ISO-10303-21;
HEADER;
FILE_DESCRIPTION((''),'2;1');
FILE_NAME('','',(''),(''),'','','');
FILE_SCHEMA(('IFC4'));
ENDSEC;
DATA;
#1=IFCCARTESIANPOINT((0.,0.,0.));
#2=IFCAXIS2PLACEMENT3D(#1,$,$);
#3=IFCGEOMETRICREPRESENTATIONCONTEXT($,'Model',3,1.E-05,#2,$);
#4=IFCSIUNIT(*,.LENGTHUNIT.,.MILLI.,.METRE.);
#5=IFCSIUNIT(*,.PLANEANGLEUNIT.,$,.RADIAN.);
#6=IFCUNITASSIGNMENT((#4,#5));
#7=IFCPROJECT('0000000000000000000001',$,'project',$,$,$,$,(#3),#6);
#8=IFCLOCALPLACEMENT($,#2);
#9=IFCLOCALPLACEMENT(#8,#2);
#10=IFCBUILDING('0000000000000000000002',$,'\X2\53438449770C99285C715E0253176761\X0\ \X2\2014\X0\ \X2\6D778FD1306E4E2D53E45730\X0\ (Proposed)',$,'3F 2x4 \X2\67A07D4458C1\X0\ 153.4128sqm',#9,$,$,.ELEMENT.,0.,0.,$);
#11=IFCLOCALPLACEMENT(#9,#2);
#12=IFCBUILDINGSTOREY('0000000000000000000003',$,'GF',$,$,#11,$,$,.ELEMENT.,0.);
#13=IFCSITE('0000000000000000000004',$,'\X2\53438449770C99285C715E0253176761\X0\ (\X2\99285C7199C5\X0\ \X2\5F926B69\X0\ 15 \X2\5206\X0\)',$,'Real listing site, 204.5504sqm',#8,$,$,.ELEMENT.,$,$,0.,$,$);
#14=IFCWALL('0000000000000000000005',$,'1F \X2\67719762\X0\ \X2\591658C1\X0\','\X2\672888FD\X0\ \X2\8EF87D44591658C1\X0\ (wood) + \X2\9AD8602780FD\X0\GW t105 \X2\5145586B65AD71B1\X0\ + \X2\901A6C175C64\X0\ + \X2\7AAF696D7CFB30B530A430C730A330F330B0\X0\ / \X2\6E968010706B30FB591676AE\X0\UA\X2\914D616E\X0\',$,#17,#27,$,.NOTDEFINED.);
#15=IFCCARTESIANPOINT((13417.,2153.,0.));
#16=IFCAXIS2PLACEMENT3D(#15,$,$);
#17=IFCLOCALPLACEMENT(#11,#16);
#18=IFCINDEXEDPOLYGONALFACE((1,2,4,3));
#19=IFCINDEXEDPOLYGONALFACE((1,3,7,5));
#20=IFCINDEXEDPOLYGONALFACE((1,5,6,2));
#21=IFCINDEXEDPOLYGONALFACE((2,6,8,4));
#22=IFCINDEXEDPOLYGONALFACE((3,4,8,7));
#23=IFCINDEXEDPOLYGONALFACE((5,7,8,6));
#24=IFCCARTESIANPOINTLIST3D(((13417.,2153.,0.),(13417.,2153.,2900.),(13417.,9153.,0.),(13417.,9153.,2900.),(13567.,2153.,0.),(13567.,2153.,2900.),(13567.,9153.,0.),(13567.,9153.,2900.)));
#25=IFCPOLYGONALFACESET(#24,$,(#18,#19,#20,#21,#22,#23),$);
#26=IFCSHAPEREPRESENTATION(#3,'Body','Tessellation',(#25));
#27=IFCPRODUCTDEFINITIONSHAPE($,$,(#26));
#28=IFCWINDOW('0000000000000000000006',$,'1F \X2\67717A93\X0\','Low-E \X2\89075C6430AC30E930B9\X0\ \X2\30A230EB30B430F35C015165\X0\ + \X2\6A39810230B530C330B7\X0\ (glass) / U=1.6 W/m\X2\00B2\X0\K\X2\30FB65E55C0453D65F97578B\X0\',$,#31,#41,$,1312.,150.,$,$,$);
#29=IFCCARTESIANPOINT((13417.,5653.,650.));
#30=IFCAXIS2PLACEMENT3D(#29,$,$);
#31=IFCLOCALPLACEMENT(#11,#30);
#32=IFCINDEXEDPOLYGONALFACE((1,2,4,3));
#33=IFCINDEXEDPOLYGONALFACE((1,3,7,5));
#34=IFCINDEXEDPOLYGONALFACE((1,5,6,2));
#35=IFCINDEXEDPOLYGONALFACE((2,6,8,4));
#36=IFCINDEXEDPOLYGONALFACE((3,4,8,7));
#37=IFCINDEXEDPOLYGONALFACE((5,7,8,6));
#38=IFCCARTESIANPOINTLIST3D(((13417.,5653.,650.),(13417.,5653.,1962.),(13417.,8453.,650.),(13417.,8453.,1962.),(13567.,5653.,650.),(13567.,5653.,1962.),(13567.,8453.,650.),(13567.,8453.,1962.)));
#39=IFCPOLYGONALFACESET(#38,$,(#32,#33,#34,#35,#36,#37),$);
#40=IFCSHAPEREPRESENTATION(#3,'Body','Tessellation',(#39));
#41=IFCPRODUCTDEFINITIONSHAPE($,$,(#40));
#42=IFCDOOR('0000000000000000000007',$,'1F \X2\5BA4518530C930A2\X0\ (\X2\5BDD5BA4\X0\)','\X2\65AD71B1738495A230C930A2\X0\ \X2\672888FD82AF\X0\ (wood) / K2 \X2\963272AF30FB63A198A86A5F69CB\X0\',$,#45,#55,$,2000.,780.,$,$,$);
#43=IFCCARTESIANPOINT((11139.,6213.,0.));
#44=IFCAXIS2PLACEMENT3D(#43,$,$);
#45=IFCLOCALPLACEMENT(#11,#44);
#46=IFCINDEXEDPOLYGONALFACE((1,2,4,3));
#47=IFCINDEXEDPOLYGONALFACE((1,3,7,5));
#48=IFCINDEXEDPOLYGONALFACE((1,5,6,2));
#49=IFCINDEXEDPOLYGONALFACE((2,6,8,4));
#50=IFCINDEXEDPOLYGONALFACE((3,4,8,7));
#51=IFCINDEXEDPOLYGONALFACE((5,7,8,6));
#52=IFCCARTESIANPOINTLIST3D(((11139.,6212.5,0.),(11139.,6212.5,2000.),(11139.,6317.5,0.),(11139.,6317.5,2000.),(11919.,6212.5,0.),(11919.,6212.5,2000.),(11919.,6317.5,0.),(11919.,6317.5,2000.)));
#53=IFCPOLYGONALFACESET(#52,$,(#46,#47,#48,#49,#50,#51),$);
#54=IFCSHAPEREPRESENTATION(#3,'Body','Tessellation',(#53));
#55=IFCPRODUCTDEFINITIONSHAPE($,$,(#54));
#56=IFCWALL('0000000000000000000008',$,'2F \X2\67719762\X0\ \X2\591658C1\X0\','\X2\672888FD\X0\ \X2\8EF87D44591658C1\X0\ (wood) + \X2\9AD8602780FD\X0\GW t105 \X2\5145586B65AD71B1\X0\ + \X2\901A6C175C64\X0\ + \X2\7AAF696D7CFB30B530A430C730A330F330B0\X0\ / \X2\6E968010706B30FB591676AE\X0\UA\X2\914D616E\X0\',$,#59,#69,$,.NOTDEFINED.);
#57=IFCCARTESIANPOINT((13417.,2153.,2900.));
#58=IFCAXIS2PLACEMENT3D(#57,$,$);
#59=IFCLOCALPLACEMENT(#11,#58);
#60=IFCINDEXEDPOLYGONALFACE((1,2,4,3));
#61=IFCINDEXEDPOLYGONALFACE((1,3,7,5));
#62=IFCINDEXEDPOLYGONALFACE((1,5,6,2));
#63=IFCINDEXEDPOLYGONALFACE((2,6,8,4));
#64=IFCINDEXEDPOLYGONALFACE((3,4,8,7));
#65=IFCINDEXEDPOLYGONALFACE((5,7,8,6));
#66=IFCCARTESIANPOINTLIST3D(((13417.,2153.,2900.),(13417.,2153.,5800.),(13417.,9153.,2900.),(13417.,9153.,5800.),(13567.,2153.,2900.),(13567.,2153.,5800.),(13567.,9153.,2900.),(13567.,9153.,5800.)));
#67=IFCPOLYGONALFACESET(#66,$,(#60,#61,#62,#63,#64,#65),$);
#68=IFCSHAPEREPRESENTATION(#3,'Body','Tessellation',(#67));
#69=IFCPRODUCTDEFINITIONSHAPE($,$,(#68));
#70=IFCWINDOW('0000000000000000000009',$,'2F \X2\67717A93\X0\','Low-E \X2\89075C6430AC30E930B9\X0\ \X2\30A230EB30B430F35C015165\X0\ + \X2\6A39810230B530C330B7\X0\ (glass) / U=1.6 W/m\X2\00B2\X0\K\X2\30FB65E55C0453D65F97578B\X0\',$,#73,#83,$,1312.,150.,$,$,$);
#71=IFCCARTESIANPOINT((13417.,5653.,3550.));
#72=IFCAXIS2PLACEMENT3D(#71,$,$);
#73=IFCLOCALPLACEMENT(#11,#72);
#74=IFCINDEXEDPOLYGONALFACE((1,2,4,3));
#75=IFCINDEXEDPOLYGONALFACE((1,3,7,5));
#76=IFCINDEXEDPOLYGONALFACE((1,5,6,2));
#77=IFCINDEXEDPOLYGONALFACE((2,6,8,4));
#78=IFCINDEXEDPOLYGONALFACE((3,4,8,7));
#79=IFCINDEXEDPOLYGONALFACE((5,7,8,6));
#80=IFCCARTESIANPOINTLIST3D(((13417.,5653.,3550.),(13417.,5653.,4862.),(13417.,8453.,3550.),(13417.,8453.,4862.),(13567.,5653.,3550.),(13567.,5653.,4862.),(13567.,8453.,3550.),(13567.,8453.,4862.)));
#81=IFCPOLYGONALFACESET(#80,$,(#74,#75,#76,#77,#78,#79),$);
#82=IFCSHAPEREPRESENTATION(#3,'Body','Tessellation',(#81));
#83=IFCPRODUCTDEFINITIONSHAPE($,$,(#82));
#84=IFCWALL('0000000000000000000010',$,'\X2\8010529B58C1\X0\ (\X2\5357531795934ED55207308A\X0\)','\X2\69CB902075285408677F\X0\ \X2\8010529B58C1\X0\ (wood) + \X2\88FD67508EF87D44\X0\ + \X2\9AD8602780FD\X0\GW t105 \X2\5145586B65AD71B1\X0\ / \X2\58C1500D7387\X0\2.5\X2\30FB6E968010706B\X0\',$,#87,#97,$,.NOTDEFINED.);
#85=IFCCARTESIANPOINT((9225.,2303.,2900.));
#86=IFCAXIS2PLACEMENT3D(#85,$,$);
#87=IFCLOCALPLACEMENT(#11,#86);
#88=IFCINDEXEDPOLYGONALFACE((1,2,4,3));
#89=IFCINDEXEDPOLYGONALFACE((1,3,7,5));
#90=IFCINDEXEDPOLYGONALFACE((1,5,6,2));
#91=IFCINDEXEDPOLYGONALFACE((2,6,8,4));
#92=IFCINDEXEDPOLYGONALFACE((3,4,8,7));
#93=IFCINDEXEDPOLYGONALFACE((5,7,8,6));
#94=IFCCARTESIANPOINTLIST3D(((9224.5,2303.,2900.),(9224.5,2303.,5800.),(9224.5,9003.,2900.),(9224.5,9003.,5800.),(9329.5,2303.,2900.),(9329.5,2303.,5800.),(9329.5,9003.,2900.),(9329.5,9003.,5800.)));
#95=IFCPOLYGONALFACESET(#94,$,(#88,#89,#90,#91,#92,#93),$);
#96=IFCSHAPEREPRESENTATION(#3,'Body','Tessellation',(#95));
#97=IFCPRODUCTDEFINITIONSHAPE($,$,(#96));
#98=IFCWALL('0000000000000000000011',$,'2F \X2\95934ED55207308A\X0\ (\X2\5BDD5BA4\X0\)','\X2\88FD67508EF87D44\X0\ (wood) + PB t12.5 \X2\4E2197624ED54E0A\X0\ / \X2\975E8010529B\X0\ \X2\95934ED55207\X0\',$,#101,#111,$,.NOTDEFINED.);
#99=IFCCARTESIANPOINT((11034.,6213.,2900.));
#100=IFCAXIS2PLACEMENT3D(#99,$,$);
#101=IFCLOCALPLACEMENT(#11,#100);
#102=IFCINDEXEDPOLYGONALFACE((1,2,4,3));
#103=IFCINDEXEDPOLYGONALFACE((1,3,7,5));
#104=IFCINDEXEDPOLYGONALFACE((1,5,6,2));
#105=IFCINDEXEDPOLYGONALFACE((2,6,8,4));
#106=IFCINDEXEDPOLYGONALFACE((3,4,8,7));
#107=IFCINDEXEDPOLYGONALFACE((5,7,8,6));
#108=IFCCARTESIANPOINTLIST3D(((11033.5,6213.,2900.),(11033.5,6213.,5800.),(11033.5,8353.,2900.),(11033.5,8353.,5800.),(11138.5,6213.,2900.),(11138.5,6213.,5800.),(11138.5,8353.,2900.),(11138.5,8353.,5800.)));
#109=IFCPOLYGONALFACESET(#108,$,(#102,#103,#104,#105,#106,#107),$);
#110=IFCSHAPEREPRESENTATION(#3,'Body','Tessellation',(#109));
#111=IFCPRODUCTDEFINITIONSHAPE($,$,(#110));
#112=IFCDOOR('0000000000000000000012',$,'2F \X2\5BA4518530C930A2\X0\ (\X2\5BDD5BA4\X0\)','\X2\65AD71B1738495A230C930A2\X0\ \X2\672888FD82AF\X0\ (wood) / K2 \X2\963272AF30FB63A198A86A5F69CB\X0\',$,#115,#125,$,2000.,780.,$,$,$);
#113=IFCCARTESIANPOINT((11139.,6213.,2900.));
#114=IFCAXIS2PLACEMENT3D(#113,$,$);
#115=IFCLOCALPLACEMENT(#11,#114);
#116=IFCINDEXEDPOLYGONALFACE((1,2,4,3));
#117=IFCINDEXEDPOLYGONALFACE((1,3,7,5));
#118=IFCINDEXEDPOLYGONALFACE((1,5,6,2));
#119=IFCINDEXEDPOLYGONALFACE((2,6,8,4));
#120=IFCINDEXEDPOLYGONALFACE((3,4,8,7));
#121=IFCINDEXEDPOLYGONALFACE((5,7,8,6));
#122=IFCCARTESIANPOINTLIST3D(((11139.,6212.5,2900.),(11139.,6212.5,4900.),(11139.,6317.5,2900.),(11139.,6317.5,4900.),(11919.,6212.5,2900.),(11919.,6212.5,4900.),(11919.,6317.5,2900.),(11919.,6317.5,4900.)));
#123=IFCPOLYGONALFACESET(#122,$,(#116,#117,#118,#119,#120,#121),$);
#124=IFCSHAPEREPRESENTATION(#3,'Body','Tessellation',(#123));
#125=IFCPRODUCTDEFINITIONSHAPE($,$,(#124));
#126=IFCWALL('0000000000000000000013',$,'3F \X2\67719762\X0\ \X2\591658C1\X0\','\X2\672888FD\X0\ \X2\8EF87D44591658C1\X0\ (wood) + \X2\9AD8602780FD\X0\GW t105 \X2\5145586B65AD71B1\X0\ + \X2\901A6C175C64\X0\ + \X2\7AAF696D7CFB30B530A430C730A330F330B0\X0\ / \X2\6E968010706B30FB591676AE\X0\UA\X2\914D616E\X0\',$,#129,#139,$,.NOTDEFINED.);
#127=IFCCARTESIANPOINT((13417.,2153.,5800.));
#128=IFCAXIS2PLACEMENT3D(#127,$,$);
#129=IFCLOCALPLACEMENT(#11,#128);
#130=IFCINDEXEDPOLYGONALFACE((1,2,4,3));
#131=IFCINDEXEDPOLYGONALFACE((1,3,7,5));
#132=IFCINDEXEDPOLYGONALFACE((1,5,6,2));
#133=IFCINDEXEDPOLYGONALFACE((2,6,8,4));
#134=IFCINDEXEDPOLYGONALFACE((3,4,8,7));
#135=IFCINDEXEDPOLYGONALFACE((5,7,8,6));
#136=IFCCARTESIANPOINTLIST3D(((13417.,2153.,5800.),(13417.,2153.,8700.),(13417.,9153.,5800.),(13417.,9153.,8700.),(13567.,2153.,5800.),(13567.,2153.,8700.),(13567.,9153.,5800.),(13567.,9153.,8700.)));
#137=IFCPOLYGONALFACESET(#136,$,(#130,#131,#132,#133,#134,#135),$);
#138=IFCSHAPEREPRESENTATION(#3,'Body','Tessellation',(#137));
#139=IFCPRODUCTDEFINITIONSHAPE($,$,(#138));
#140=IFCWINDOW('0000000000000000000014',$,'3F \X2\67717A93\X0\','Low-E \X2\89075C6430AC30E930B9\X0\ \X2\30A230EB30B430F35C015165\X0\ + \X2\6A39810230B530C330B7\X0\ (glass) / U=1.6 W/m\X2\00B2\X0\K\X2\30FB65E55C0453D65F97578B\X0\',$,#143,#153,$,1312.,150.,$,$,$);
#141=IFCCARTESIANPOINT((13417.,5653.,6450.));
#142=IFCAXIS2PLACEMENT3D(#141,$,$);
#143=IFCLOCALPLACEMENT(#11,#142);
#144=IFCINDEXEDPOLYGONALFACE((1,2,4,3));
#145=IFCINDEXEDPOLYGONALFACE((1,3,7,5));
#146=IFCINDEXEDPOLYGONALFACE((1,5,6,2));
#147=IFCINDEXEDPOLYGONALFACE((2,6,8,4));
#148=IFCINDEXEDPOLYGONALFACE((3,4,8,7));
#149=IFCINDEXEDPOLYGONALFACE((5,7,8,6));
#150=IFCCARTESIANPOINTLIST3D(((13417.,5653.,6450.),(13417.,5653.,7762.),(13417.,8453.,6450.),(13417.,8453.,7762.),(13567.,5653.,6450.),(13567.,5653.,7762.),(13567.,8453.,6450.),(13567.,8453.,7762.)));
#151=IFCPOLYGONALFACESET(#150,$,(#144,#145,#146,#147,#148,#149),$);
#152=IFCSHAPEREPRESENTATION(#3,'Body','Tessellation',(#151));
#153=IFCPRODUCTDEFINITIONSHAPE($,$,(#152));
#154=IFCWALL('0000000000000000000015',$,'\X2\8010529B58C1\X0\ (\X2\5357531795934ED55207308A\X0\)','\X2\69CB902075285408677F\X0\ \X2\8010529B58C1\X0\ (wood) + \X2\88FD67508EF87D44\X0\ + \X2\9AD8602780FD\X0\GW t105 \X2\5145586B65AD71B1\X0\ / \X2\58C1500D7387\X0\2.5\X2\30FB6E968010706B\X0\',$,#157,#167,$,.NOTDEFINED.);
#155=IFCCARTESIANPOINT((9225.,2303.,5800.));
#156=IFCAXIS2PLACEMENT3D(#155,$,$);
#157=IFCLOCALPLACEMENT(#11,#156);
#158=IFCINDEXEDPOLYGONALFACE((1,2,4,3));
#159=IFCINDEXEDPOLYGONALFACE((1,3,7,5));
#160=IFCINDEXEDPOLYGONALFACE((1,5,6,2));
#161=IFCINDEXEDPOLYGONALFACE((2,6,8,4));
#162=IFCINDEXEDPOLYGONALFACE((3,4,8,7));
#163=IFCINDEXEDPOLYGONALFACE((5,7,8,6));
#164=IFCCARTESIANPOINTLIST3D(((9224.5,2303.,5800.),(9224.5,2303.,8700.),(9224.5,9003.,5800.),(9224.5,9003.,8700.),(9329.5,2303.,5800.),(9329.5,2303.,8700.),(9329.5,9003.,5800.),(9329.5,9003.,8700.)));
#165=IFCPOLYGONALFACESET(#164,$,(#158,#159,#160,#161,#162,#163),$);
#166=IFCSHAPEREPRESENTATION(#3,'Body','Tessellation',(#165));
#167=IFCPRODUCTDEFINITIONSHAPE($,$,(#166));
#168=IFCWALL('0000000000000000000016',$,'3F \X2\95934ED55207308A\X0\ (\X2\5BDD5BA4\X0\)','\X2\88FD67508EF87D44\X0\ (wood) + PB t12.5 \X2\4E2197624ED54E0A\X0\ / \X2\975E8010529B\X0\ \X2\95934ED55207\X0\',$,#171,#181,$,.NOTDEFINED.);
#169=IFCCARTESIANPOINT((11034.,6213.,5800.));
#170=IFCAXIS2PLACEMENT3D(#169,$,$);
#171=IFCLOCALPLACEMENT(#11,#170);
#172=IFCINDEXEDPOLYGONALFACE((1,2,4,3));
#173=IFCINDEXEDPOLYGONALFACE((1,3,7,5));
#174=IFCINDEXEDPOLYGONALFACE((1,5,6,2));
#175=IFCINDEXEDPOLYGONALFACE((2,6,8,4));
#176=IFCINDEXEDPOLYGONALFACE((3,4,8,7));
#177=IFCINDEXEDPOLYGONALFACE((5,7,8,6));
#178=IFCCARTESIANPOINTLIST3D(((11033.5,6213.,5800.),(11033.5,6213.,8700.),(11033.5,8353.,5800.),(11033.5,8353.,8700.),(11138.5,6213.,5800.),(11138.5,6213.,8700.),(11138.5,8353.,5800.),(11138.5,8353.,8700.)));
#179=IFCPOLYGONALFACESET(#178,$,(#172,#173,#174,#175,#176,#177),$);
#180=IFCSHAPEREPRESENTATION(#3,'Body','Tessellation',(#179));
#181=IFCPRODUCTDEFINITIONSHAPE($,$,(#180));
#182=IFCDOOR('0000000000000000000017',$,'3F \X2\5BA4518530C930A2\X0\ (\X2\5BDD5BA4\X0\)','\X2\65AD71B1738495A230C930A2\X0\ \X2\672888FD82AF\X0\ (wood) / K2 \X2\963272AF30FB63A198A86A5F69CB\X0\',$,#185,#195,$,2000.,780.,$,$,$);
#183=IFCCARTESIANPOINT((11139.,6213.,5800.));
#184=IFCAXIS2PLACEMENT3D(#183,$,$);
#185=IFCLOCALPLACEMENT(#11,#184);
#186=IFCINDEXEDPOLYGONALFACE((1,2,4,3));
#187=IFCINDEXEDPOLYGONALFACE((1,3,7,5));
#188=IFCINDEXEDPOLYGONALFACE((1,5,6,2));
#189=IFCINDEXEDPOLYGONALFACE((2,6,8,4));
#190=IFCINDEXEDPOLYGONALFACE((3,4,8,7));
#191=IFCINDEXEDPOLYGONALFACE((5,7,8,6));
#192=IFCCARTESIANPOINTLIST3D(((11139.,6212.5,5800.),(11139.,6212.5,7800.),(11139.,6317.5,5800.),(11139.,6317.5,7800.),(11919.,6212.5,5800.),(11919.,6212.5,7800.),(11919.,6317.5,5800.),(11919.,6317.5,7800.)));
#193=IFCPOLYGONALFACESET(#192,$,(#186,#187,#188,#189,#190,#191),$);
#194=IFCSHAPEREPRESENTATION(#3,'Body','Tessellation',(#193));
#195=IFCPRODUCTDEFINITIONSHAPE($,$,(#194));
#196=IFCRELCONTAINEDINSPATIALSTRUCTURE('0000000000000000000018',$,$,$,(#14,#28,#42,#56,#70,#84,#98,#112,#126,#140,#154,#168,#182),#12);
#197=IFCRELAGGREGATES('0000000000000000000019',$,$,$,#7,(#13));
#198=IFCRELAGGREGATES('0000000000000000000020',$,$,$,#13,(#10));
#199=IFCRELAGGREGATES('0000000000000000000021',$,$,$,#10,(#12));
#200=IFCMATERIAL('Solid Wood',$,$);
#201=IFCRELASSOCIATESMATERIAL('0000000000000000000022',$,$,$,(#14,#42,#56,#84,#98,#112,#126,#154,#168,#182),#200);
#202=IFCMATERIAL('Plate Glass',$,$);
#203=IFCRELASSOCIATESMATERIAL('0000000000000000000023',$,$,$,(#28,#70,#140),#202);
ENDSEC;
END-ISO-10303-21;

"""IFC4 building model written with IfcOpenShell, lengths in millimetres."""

from ifc_helpers import new_model, si_unit, frame, frame_2d, origin, place, context, project, spatial, rectangle, extrude, material, element, fill, save


model = new_model("IFC4")

# Units and contexts
model_context = context("Model", 3, precision=1e-05, world=origin())
ifc_project = project(units=[si_unit("LENGTHUNIT", "METRE", prefix="MILLI"), si_unit("PLANEANGLEUNIT", "RADIAN")], contexts=[model_context])

# Site, building, storey
site_placement = place(None, origin())
site = spatial("IfcSite", under=ifc_project, at=site_placement, Name="千葉県館山市北条 (館山駅 徒歩 15 分)", ObjectType="Real listing site, 204.5504sqm", CompositionType="ELEMENT", RefElevation=0.0)
building_placement = place(site_placement, origin())
building = spatial("IfcBuilding", under=site, at=building_placement, Name="千葉県館山市北条 — 海近の中古地 (Proposed)", ObjectType="3F 2x4 枠組壁 153.4128sqm", CompositionType="ELEMENT", ElevationOfRefHeight=0.0, ElevationOfTerrain=0.0)
storey_placement = place(building_placement, origin())
storey = spatial("IfcBuildingStorey", under=building, at=storey_placement, Name="GF", CompositionType="ELEMENT", Elevation=0.0)

# Wall, opening, window
ifc_material_1 = material(Name="Solid Wood")
wall_1_placement = place(storey_placement, frame((13417.0, 2153.0, 0.0)))
wall_1 = element("IfcWall", 1, at=wall_1_placement, inside=storey, material=ifc_material_1, Name="1F 東面 外壁", Description="木製 軸組外壁 (wood) + 高性能GW t105 充填断熱 + 通気層 + 窯業系サイディング / 準耐火・外皮UA配慮", PredefinedType="NOTDEFINED", context=model_context, shape_type="SweptSolid", body=[
    extrude(rectangle(XDim=150.0, YDim=7000.0, at=frame_2d((75.0, 3500.0))), frame((13417.0, 2153.0, 0.0)), (0.0, 0.0, 1.0), 2900.0),
])
opening_1_placement = place(storey_placement, frame((13417.0, 5653.0, 650.0)))
opening_1 = element("IfcOpeningElement", 2, at=opening_1_placement, cuts=wall_1, PredefinedType="NOTDEFINED", context=model_context, shape_type="SweptSolid", body=[
    extrude(rectangle(XDim=150.0, YDim=2800.0, at=frame_2d((75.0, 1400.0))), frame((13417.0, 5653.0, 650.0)), (0.0, 0.0, 1.0), 1312.0),
])
ifc_material_2 = material(Name="Plate Glass")
window_1_placement = place(storey_placement, frame((13417.0, 5653.0, 650.0)))
window_1 = element("IfcWindow", 3, at=window_1_placement, inside=storey, material=ifc_material_2, Name="1F 東窓", Description="Low-E 複層ガラス アルゴン封入 + 樹脂サッシ (glass) / U=1.6 W/m²K・日射取得型", OverallHeight=1312.0, OverallWidth=150.0, context=model_context, shape_type="SweptSolid", body=[
    extrude(rectangle(XDim=150.0, YDim=2800.0, at=frame_2d((75.0, 1400.0))), frame((13417.0, 5653.0, 650.0)), (0.0, 0.0, 1.0), 1312.0),
])
fill(opening_1, window_1)

# Door
door_1_placement = place(storey_placement, frame((11139.0, 6213.0, 0.0)))
element("IfcDoor", 4, at=door_1_placement, inside=storey, material=ifc_material_1, Name="1F 室内ドア (寝室)", Description="断熱玄関ドア 木製芯 (wood) / K2 防犯・採風機構", OverallHeight=2000.0, OverallWidth=780.0, context=model_context, shape_type="SweptSolid", body=[
    extrude(rectangle(XDim=780.0, YDim=105.0, at=frame_2d((390.0, 52.0))), frame((11139.0, 6213.0, 0.0)), (0.0, 0.0, 1.0), 2000.0),
])

# Wall, opening, window
wall_2_placement = place(storey_placement, frame((13417.0, 2153.0, 2900.0)))
wall_2 = element("IfcWall", 5, at=wall_2_placement, inside=storey, material=ifc_material_1, Name="2F 東面 外壁", Description="木製 軸組外壁 (wood) + 高性能GW t105 充填断熱 + 通気層 + 窯業系サイディング / 準耐火・外皮UA配慮", PredefinedType="NOTDEFINED", context=model_context, shape_type="SweptSolid", body=[
    extrude(rectangle(XDim=150.0, YDim=7000.0, at=frame_2d((75.0, 3500.0))), frame((13417.0, 2153.0, 2900.0)), (0.0, 0.0, 1.0), 2900.0),
])
opening_2_placement = place(storey_placement, frame((13417.0, 5653.0, 3550.0)))
opening_2 = element("IfcOpeningElement", 6, at=opening_2_placement, cuts=wall_2, PredefinedType="NOTDEFINED", context=model_context, shape_type="SweptSolid", body=[
    extrude(rectangle(XDim=150.0, YDim=2800.0, at=frame_2d((75.0, 1400.0))), frame((13417.0, 5653.0, 3550.0)), (0.0, 0.0, 1.0), 1312.0),
])
window_2_placement = place(storey_placement, frame((13417.0, 5653.0, 3550.0)))
window_2 = element("IfcWindow", 7, at=window_2_placement, inside=storey, material=ifc_material_2, Name="2F 東窓", Description="Low-E 複層ガラス アルゴン封入 + 樹脂サッシ (glass) / U=1.6 W/m²K・日射取得型", OverallHeight=1312.0, OverallWidth=150.0, context=model_context, shape_type="SweptSolid", body=[
    extrude(rectangle(XDim=150.0, YDim=2800.0, at=frame_2d((75.0, 1400.0))), frame((13417.0, 5653.0, 3550.0)), (0.0, 0.0, 1.0), 1312.0),
])
fill(opening_2, window_2)

# Walls
wall_3_placement = place(storey_placement, frame((9225.0, 2303.0, 2900.0)))
element("IfcWall", 8, at=wall_3_placement, inside=storey, material=ifc_material_1, Name="耐力壁 (南北間仕切り)", Description="構造用合板 耐力壁 (wood) + 製材軸組 + 高性能GW t105 充填断熱 / 壁倍率2.5・準耐火", PredefinedType="NOTDEFINED", context=model_context, shape_type="SweptSolid", body=[
    extrude(rectangle(XDim=105.0, YDim=6700.0, at=frame_2d((52.0, 3350.0))), frame((9225.0, 2303.0, 2900.0)), (0.0, 0.0, 1.0), 2900.0),
])
wall_4_placement = place(storey_placement, frame((11034.0, 6213.0, 2900.0)))
element("IfcWall", 9, at=wall_4_placement, inside=storey, material=ifc_material_1, Name="2F 間仕切り (寝室)", Description="製材軸組 (wood) + PB t12.5 両面仕上 / 非耐力 間仕切", PredefinedType="NOTDEFINED", context=model_context, shape_type="SweptSolid", body=[
    extrude(rectangle(XDim=105.0, YDim=2140.0, at=frame_2d((52.0, 1070.0))), frame((11034.0, 6213.0, 2900.0)), (0.0, 0.0, 1.0), 2900.0),
])

# Door
door_2_placement = place(storey_placement, frame((11139.0, 6213.0, 2900.0)))
element("IfcDoor", 10, at=door_2_placement, inside=storey, material=ifc_material_1, Name="2F 室内ドア (寝室)", Description="断熱玄関ドア 木製芯 (wood) / K2 防犯・採風機構", OverallHeight=2000.0, OverallWidth=780.0, context=model_context, shape_type="SweptSolid", body=[
    extrude(rectangle(XDim=780.0, YDim=105.0, at=frame_2d((390.0, 52.0))), frame((11139.0, 6213.0, 2900.0)), (0.0, 0.0, 1.0), 2000.0),
])

# Wall, opening, window
wall_5_placement = place(storey_placement, frame((13417.0, 2153.0, 5800.0)))
wall_5 = element("IfcWall", 11, at=wall_5_placement, inside=storey, material=ifc_material_1, Name="3F 東面 外壁", Description="木製 軸組外壁 (wood) + 高性能GW t105 充填断熱 + 通気層 + 窯業系サイディング / 準耐火・外皮UA配慮", PredefinedType="NOTDEFINED", context=model_context, shape_type="SweptSolid", body=[
    extrude(rectangle(XDim=150.0, YDim=7000.0, at=frame_2d((75.0, 3500.0))), frame((13417.0, 2153.0, 5800.0)), (0.0, 0.0, 1.0), 2900.0),
])
opening_3_placement = place(storey_placement, frame((13417.0, 5653.0, 6450.0)))
opening_3 = element("IfcOpeningElement", 12, at=opening_3_placement, cuts=wall_5, PredefinedType="NOTDEFINED", context=model_context, shape_type="SweptSolid", body=[
    extrude(rectangle(XDim=150.0, YDim=2800.0, at=frame_2d((75.0, 1400.0))), frame((13417.0, 5653.0, 6450.0)), (0.0, 0.0, 1.0), 1312.0),
])
window_3_placement = place(storey_placement, frame((13417.0, 5653.0, 6450.0)))
window_3 = element("IfcWindow", 13, at=window_3_placement, inside=storey, material=ifc_material_2, Name="3F 東窓", Description="Low-E 複層ガラス アルゴン封入 + 樹脂サッシ (glass) / U=1.6 W/m²K・日射取得型", OverallHeight=1312.0, OverallWidth=150.0, context=model_context, shape_type="SweptSolid", body=[
    extrude(rectangle(XDim=150.0, YDim=2800.0, at=frame_2d((75.0, 1400.0))), frame((13417.0, 5653.0, 6450.0)), (0.0, 0.0, 1.0), 1312.0),
])
fill(opening_3, window_3)

# Walls
wall_6_placement = place(storey_placement, frame((9225.0, 2303.0, 5800.0)))
element("IfcWall", 14, at=wall_6_placement, inside=storey, material=ifc_material_1, Name="耐力壁 (南北間仕切り)", Description="構造用合板 耐力壁 (wood) + 製材軸組 + 高性能GW t105 充填断熱 / 壁倍率2.5・準耐火", PredefinedType="NOTDEFINED", context=model_context, shape_type="SweptSolid", body=[
    extrude(rectangle(XDim=105.0, YDim=6700.0, at=frame_2d((52.0, 3350.0))), frame((9225.0, 2303.0, 5800.0)), (0.0, 0.0, 1.0), 2900.0),
])
wall_7_placement = place(storey_placement, frame((11034.0, 6213.0, 5800.0)))
element("IfcWall", 15, at=wall_7_placement, inside=storey, material=ifc_material_1, Name="3F 間仕切り (寝室)", Description="製材軸組 (wood) + PB t12.5 両面仕上 / 非耐力 間仕切", PredefinedType="NOTDEFINED", context=model_context, shape_type="SweptSolid", body=[
    extrude(rectangle(XDim=105.0, YDim=2140.0, at=frame_2d((52.0, 1070.0))), frame((11034.0, 6213.0, 5800.0)), (0.0, 0.0, 1.0), 2900.0),
])

# Door
door_3_placement = place(storey_placement, frame((11139.0, 6213.0, 5800.0)))
element("IfcDoor", 16, at=door_3_placement, inside=storey, material=ifc_material_1, Name="3F 室内ドア (寝室)", Description="断熱玄関ドア 木製芯 (wood) / K2 防犯・採風機構", OverallHeight=2000.0, OverallWidth=780.0, context=model_context, shape_type="SweptSolid", body=[
    extrude(rectangle(XDim=780.0, YDim=105.0, at=frame_2d((390.0, 52.0))), frame((11139.0, 6213.0, 5800.0)), (0.0, 0.0, 1.0), 2000.0),
])

save(model, "model.ifc")
